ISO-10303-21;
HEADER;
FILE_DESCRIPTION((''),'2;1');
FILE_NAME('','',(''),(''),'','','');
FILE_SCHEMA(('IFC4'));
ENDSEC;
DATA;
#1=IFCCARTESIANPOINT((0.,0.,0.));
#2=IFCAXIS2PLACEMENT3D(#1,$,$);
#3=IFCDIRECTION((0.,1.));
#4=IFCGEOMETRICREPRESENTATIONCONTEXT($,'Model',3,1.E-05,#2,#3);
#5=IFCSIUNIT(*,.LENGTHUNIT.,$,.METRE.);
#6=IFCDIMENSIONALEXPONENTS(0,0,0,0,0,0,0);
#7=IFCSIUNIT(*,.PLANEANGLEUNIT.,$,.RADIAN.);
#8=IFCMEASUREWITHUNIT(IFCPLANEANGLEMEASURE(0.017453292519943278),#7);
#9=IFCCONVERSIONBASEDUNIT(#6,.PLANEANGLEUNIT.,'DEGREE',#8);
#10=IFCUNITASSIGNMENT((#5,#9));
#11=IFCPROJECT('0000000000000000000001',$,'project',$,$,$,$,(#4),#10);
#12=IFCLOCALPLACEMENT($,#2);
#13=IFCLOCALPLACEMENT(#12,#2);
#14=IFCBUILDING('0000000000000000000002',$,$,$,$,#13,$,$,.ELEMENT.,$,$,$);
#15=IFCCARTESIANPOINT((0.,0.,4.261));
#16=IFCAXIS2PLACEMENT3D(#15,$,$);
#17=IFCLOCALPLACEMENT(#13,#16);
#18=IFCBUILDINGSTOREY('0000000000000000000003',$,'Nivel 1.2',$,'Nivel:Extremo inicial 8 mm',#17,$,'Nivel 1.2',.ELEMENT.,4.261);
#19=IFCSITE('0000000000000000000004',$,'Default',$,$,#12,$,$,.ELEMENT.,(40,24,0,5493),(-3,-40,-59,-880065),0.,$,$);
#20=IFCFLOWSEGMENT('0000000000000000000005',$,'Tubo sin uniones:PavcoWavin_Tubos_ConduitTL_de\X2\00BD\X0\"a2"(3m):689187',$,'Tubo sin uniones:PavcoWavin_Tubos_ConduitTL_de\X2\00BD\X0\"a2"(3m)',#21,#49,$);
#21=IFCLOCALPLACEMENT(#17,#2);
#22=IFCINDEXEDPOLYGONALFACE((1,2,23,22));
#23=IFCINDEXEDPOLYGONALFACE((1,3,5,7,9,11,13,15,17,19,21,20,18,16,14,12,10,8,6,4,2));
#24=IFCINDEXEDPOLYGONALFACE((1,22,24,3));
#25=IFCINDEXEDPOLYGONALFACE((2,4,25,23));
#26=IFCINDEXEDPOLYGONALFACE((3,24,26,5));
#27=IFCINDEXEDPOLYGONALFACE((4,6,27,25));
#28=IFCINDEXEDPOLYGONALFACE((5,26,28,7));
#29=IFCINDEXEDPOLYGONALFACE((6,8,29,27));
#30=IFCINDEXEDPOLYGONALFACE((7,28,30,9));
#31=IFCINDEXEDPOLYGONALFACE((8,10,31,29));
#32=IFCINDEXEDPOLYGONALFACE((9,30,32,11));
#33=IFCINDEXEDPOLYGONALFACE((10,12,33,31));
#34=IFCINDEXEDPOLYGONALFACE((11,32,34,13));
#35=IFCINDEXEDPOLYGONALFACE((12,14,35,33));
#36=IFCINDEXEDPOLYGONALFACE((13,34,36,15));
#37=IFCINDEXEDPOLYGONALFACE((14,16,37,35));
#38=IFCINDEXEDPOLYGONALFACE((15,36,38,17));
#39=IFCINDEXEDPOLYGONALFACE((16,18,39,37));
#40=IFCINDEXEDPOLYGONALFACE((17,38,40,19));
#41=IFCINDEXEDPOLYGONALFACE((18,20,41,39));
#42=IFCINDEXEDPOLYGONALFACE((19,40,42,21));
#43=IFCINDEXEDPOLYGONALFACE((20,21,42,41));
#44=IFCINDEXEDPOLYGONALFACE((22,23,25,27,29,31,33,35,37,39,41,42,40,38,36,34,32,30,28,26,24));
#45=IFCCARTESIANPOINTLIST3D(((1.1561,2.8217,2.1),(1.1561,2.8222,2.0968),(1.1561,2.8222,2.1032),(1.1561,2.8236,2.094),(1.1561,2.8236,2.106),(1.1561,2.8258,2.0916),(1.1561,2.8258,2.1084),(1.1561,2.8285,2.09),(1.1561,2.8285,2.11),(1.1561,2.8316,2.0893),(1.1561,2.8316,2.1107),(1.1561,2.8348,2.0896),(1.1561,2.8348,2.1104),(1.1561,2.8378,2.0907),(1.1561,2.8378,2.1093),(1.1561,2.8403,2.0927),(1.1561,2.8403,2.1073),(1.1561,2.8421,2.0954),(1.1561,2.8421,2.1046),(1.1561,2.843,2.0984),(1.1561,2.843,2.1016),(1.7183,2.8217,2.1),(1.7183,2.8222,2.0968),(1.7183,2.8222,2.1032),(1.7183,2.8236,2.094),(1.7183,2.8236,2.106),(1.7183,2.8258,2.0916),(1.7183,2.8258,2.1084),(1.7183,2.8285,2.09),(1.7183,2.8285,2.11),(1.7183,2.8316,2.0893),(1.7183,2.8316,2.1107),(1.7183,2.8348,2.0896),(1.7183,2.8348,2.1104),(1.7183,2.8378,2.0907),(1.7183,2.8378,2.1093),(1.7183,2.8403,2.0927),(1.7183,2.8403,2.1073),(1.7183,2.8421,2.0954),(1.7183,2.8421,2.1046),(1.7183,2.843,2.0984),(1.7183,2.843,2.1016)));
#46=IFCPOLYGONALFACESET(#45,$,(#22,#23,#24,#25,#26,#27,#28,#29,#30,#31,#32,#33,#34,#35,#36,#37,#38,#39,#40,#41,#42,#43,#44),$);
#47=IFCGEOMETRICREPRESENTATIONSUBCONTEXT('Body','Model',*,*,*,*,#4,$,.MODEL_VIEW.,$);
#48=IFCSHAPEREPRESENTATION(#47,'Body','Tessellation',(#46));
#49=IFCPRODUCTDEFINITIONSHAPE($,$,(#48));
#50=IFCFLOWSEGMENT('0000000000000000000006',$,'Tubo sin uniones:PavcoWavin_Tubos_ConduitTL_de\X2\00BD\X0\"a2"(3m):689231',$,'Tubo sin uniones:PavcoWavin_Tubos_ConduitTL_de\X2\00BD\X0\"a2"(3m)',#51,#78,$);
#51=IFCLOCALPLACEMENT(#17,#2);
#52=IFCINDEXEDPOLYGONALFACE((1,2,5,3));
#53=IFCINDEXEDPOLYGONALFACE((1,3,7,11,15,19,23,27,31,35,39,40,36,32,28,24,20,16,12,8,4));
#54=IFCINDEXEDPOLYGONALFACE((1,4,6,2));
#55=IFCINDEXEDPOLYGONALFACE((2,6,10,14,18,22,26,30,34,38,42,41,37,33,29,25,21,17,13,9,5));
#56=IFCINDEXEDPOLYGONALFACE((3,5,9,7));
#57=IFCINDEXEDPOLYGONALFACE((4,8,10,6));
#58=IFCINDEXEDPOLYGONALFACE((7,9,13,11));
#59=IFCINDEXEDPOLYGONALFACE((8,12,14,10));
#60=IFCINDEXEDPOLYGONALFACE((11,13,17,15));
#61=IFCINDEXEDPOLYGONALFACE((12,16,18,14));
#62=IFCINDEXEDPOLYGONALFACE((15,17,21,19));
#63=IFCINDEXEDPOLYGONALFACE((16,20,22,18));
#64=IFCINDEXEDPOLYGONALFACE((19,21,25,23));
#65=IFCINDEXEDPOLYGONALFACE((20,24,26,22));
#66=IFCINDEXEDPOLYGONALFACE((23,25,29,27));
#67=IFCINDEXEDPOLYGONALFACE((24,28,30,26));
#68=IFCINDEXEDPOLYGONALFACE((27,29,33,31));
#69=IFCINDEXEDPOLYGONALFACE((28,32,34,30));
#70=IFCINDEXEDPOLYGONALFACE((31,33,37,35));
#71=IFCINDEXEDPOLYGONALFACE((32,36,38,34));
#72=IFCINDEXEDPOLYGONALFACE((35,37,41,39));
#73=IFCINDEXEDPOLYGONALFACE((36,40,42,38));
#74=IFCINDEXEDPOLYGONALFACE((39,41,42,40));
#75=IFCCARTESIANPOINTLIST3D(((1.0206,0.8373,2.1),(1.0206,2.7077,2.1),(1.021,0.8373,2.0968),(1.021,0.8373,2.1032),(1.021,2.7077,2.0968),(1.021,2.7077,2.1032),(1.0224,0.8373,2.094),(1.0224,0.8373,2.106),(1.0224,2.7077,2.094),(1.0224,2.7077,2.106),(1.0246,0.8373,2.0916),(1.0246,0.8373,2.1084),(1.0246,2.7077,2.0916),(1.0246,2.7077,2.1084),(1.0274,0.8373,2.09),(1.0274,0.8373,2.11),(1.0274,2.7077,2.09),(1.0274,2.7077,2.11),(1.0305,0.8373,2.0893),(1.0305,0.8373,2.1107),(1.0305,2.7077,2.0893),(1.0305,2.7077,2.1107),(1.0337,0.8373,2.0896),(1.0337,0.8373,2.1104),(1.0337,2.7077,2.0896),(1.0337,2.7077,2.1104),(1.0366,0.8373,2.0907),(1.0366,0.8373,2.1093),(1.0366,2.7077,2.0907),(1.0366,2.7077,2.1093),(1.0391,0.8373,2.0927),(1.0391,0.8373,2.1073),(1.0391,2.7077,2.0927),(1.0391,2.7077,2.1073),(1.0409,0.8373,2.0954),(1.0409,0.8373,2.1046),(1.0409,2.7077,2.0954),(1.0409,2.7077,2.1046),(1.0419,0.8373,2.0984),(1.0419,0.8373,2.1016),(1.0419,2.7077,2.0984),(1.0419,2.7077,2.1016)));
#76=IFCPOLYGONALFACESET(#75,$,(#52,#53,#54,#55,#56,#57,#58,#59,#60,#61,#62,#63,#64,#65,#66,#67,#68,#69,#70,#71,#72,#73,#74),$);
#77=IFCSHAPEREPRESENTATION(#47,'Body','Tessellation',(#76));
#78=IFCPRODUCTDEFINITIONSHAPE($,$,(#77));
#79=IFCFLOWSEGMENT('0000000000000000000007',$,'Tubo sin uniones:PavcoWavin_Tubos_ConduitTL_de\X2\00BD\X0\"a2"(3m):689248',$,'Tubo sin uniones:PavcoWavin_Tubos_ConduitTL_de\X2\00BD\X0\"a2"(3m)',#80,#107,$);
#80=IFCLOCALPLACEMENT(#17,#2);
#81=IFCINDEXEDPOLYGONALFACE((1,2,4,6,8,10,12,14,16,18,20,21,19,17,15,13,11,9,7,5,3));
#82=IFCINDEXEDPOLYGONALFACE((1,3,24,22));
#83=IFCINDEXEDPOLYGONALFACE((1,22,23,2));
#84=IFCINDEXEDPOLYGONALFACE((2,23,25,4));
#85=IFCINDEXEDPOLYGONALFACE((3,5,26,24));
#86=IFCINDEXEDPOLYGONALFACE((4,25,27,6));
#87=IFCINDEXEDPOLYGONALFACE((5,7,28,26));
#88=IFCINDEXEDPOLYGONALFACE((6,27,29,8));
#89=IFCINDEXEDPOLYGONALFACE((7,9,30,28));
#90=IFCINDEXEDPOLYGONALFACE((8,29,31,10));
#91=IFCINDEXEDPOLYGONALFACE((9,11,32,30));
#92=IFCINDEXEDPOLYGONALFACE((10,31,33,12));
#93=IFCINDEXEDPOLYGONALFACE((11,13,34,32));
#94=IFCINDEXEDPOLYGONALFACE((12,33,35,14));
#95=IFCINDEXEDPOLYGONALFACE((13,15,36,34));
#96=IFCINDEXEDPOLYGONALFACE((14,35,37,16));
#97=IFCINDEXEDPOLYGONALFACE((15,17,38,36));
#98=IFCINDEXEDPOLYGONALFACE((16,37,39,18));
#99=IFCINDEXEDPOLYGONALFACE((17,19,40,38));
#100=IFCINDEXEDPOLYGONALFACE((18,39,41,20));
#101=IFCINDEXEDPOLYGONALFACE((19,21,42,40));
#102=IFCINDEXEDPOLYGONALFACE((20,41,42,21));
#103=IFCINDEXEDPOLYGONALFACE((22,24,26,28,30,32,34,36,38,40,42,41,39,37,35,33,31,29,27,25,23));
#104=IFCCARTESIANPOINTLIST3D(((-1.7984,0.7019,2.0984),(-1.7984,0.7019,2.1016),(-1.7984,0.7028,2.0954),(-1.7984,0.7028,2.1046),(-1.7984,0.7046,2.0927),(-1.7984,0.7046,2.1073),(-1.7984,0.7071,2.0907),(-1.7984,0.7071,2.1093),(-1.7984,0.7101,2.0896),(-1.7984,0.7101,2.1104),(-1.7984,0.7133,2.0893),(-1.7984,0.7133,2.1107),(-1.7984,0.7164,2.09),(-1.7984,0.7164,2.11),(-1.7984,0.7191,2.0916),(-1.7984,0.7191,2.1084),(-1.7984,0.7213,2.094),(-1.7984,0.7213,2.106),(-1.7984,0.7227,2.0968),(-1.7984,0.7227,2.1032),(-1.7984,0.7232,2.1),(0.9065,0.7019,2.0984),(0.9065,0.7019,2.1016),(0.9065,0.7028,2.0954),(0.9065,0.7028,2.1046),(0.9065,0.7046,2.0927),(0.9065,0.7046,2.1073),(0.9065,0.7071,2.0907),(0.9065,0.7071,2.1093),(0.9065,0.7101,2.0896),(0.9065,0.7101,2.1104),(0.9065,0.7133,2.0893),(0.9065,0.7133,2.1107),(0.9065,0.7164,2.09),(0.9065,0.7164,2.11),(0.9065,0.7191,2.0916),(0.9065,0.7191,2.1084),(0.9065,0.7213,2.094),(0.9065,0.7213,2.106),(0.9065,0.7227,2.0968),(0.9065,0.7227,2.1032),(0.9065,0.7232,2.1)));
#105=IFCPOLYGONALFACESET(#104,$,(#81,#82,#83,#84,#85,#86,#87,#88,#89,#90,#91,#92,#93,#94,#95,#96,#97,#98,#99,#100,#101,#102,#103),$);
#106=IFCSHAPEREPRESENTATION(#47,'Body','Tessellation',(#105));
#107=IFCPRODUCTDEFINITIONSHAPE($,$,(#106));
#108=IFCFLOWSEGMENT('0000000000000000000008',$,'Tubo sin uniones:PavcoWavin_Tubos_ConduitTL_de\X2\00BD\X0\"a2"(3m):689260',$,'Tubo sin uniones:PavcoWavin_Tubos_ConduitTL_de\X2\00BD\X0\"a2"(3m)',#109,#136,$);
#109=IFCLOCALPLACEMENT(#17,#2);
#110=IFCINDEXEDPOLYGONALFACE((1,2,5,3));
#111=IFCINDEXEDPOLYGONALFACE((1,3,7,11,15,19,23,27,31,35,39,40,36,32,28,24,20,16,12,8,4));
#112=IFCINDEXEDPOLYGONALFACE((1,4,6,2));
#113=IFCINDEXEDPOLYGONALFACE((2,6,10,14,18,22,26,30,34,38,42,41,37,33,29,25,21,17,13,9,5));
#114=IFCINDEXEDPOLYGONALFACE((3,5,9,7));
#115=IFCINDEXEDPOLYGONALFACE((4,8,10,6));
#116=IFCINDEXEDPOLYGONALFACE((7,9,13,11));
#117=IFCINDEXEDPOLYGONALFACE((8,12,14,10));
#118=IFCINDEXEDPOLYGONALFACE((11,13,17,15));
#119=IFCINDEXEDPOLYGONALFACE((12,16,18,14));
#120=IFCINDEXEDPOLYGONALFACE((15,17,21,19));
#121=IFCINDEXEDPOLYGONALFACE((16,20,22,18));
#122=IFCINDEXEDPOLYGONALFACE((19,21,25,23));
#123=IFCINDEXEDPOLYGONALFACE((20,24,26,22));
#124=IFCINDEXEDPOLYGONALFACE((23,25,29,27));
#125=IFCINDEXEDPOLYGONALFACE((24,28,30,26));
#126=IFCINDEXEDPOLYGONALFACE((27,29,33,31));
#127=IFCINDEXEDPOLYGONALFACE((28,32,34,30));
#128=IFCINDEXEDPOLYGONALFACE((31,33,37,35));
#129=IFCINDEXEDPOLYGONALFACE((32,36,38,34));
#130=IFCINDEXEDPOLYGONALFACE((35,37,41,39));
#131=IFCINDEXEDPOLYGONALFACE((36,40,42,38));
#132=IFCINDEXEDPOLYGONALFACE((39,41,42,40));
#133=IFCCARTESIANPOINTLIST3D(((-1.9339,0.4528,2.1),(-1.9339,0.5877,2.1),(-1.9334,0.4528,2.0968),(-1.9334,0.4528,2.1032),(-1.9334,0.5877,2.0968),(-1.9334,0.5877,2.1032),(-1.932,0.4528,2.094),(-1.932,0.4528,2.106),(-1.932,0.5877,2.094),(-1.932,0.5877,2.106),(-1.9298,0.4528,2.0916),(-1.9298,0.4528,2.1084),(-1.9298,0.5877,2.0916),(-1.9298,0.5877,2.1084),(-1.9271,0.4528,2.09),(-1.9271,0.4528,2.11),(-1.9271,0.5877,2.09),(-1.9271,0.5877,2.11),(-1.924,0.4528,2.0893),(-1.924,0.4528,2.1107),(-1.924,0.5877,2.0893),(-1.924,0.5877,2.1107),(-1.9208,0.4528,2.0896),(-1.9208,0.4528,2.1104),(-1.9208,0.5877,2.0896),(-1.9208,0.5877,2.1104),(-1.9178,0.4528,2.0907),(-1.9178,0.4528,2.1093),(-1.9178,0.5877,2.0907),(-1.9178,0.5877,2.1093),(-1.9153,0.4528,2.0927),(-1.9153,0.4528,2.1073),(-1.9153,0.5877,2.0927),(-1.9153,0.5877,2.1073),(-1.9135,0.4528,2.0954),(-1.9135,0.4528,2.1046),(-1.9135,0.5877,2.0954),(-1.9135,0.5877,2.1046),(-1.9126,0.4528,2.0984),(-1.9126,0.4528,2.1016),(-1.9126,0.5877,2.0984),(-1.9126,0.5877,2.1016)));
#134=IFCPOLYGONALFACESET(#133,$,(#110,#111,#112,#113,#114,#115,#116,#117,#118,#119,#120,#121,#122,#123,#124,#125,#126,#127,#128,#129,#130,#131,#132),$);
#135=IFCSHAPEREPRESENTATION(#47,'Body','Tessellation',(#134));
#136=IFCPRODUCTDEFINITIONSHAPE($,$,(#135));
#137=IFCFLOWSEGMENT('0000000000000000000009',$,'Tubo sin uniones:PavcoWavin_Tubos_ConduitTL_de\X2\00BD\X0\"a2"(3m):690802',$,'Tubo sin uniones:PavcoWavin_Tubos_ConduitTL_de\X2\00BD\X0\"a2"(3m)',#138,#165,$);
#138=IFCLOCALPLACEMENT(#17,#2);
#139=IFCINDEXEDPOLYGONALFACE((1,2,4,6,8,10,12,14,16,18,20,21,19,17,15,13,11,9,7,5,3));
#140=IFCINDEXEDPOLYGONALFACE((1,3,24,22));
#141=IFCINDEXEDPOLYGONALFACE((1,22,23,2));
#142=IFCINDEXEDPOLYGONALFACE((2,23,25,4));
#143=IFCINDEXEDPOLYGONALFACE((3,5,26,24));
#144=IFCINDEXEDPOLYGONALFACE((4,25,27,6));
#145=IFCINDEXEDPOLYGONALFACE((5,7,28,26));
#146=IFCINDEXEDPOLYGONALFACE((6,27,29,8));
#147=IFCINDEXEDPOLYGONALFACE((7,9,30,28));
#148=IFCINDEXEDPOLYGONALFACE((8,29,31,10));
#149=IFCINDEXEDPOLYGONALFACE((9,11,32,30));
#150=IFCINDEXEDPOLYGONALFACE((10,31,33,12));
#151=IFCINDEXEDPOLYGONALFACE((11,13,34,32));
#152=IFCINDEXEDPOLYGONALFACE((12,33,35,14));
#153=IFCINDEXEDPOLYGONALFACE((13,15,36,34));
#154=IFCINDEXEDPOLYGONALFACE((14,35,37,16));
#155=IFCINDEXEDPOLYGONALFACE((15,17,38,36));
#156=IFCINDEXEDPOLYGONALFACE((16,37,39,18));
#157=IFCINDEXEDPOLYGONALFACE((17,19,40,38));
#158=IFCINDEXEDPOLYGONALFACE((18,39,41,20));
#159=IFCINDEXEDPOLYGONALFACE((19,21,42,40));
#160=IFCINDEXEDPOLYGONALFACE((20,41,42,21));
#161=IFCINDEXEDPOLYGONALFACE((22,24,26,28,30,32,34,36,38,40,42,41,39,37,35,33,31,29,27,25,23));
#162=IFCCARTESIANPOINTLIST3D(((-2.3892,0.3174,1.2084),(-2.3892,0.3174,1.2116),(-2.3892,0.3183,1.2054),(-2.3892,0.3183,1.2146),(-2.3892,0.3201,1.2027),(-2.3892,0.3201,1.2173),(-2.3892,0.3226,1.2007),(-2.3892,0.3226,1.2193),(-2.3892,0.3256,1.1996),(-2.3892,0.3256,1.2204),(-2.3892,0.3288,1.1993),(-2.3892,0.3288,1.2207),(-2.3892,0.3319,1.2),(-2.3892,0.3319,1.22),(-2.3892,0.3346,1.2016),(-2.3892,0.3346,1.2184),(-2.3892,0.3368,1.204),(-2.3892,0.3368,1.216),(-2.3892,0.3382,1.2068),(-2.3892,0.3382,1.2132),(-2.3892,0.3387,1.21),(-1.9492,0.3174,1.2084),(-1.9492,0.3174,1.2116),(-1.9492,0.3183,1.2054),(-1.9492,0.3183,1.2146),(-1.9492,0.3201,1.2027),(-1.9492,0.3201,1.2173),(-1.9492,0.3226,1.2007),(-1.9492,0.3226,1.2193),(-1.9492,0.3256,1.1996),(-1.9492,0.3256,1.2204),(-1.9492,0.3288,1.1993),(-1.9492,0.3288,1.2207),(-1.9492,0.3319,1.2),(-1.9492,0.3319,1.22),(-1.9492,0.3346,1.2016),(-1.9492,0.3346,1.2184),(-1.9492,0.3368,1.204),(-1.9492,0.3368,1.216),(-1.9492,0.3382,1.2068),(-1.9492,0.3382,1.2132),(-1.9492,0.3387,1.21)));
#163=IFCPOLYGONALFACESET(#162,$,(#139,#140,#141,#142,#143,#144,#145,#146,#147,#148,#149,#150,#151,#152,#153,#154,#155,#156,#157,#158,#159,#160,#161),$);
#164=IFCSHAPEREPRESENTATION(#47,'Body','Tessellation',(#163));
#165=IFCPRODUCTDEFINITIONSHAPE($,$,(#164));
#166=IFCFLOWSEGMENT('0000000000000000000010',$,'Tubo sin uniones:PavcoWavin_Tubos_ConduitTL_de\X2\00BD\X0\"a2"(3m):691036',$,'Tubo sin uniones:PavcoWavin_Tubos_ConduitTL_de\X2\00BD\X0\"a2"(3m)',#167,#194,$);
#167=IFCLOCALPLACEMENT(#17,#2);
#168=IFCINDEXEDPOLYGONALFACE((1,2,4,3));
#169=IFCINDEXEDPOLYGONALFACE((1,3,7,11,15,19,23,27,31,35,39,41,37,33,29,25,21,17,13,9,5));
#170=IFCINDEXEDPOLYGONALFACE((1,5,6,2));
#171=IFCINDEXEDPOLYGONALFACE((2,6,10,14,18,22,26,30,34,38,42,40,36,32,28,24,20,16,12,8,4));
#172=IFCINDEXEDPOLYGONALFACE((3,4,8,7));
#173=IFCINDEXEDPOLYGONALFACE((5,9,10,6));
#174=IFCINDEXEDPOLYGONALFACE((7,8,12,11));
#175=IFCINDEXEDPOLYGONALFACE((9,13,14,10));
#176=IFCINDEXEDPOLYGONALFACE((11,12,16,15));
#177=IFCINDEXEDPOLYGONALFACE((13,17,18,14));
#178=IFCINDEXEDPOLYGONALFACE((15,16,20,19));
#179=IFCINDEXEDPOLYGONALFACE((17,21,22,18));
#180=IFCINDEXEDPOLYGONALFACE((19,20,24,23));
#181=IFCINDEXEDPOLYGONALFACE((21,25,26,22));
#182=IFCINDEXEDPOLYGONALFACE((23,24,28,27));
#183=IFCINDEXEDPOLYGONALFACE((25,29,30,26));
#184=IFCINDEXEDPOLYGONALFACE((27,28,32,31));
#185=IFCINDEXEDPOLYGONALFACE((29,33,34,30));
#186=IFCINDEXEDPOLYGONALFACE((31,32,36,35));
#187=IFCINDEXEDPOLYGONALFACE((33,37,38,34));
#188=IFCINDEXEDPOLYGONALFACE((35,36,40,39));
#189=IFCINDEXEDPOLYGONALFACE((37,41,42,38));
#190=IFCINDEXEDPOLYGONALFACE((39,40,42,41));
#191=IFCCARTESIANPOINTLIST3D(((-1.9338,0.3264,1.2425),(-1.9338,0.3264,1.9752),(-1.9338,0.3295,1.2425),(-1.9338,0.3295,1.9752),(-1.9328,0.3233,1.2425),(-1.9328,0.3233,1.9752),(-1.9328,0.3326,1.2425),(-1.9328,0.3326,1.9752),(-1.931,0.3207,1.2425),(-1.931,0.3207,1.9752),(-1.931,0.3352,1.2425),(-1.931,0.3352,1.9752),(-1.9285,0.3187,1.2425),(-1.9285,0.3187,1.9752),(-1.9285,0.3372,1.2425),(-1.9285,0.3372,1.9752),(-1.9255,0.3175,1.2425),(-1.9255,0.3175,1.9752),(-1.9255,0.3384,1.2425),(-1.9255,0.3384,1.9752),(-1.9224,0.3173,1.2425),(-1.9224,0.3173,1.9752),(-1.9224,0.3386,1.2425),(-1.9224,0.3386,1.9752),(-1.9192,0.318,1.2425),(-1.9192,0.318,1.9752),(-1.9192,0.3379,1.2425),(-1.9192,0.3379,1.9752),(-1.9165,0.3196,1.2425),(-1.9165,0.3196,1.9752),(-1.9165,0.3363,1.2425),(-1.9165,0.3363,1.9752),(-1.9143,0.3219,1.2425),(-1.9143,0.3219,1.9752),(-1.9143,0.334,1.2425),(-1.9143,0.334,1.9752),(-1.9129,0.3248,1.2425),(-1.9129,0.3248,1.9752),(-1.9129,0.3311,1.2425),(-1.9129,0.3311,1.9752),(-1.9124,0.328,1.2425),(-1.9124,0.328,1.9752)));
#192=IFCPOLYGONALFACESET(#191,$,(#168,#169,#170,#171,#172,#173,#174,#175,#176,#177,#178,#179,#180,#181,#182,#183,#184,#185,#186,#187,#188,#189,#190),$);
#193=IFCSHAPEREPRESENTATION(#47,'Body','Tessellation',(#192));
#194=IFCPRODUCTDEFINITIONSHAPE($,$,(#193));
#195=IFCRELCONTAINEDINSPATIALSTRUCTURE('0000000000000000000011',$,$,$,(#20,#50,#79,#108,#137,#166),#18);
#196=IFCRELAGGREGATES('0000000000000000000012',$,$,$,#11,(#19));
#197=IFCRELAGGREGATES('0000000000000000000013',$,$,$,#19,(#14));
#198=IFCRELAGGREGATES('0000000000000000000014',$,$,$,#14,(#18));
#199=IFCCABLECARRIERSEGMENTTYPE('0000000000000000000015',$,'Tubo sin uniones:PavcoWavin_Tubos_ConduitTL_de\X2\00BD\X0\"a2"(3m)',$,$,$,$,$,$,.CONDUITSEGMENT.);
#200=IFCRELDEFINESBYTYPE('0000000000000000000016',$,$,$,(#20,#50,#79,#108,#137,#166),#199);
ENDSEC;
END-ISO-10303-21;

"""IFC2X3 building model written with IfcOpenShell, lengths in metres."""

from ifc_helpers import new_model, entity, si_unit, converted_unit, direction, frame, frame_2d, origin, origin_2d_with_axis, place, context, subcontext, project, spatial, circle, extrude, type_object, element, save


model = new_model("IFC2X3")

# Units and contexts
model_context = context("Model", 3, precision=1e-05, world=origin(), true_north=direction((0.0, 1.0)))
body_context = subcontext(model_context, "Body", "Model", "MODEL_VIEW")
ifc_project = project(units=[si_unit("LENGTHUNIT", "METRE"), converted_unit("PLANEANGLEUNIT", "DEGREE", entity("IfcPlaneAngleMeasure", 0.017453292519943278), si_unit("PLANEANGLEUNIT", "RADIAN"), dimensions=[0, 0, 0, 0, 0, 0, 0])], contexts=[model_context])

# Site, building, storey
site_placement = place(None, origin())
site = spatial("IfcSite", under=ifc_project, at=site_placement, Name="Default", CompositionType="ELEMENT", RefLatitude=(40, 24, 0, 5493), RefLongitude=(-3, -40, -59, -880065), RefElevation=0.0)
building_placement = place(site_placement, origin())
building = spatial("IfcBuilding", under=site, at=building_placement, CompositionType="ELEMENT")
storey_placement = place(building_placement, frame((0.0, 0.0, 4.261)))
storey = spatial("IfcBuildingStorey", under=building, at=storey_placement, Name="Nivel 1.2", ObjectType="Nivel:Extremo inicial 8 mm", LongName="Nivel 1.2", CompositionType="ELEMENT", Elevation=4.261)

# Flow segments
cable_carrier_segment_type_1 = type_object("IfcCableCarrierSegmentType", Name="Tubo sin uniones:PavcoWavin_Tubos_ConduitTL_de½\"a2\"(3m)", PredefinedType="CONDUITSEGMENT")
flow_segment_1_placement = place(storey_placement, origin())
element("IfcFlowSegment", 1, at=flow_segment_1_placement, inside=storey, type_object=cable_carrier_segment_type_1, Name="Tubo sin uniones:PavcoWavin_Tubos_ConduitTL_de½\"a2\"(3m):689187", ObjectType="Tubo sin uniones:PavcoWavin_Tubos_ConduitTL_de½\"a2\"(3m)", context=body_context, shape_type="SweptSolid", body=[
    extrude(circle(Radius=0.0107, at=origin_2d_with_axis()), frame((1.1561, 2.8325, 2.1), z_axis=(1.0, 0.0, 0.0), x_axis=(0.0, -1.0, 0.0)), (0.0, 0.0, 1.0), 0.5622),
])
flow_segment_2_placement = place(storey_placement, origin())
element("IfcFlowSegment", 2, at=flow_segment_2_placement, inside=storey, type_object=cable_carrier_segment_type_1, Name="Tubo sin uniones:PavcoWavin_Tubos_ConduitTL_de½\"a2\"(3m):689231", ObjectType="Tubo sin uniones:PavcoWavin_Tubos_ConduitTL_de½\"a2\"(3m)", context=body_context, shape_type="SweptSolid", body=[
    extrude(circle(Radius=0.0107, at=frame_2d((0.0, 0.0), x_axis=(1.0, 0.0))), frame((1.0313, 0.8373, 2.1), z_axis=(0.0, 1.0, 0.0), x_axis=(-1.0, 0.0, 0.0)), (0.0, 0.0, 1.0), 1.8704),
])
flow_segment_3_placement = place(storey_placement, origin())
element("IfcFlowSegment", 3, at=flow_segment_3_placement, inside=storey, type_object=cable_carrier_segment_type_1, Name="Tubo sin uniones:PavcoWavin_Tubos_ConduitTL_de½\"a2\"(3m):689248", ObjectType="Tubo sin uniones:PavcoWavin_Tubos_ConduitTL_de½\"a2\"(3m)", context=body_context, shape_type="SweptSolid", body=[
    extrude(circle(Radius=0.0107, at=frame_2d((0.0, 0.0), x_axis=(1.0, 0.0))), frame((-1.7984, 0.7125, 2.1), z_axis=(1.0, 0.0, 0.0), x_axis=(0.0, 1.0, 0.0)), (0.0, 0.0, 1.0), 2.7048),
])
flow_segment_4_placement = place(storey_placement, origin())
element("IfcFlowSegment", 4, at=flow_segment_4_placement, inside=storey, type_object=cable_carrier_segment_type_1, Name="Tubo sin uniones:PavcoWavin_Tubos_ConduitTL_de½\"a2\"(3m):689260", ObjectType="Tubo sin uniones:PavcoWavin_Tubos_ConduitTL_de½\"a2\"(3m)", context=body_context, shape_type="SweptSolid", body=[
    extrude(circle(Radius=0.0107, at=frame_2d((0.0, 0.0), x_axis=(1.0, 0.0))), frame((-1.9232, 0.4528, 2.1), z_axis=(0.0, 1.0, 0.0), x_axis=(-1.0, 0.0, 0.0)), (0.0, 0.0, 1.0), 0.1349),
])
flow_segment_5_placement = place(storey_placement, origin())
element("IfcFlowSegment", 5, at=flow_segment_5_placement, inside=storey, type_object=cable_carrier_segment_type_1, Name="Tubo sin uniones:PavcoWavin_Tubos_ConduitTL_de½\"a2\"(3m):690802", ObjectType="Tubo sin uniones:PavcoWavin_Tubos_ConduitTL_de½\"a2\"(3m)", context=body_context, shape_type="SweptSolid", body=[
    extrude(circle(Radius=0.0107, at=frame_2d((0.0, 0.0), x_axis=(1.0, 0.0))), frame((-2.3892, 0.328, 1.21), z_axis=(1.0, 0.0, 0.0), x_axis=(0.0, 1.0, 0.0)), (0.0, 0.0, 1.0), 0.44),
])
flow_segment_6_placement = place(storey_placement, origin())
element("IfcFlowSegment", 6, at=flow_segment_6_placement, inside=storey, type_object=cable_carrier_segment_type_1, Name="Tubo sin uniones:PavcoWavin_Tubos_ConduitTL_de½\"a2\"(3m):691036", ObjectType="Tubo sin uniones:PavcoWavin_Tubos_ConduitTL_de½\"a2\"(3m)", context=body_context, shape_type="SweptSolid", body=[
    extrude(circle(Radius=0.0107, at=origin_2d_with_axis()), frame((-1.9232, 0.328, 1.2425)), (0.0, 0.0, 1.0), 0.7327),
])

save(model, "model.ifc")
